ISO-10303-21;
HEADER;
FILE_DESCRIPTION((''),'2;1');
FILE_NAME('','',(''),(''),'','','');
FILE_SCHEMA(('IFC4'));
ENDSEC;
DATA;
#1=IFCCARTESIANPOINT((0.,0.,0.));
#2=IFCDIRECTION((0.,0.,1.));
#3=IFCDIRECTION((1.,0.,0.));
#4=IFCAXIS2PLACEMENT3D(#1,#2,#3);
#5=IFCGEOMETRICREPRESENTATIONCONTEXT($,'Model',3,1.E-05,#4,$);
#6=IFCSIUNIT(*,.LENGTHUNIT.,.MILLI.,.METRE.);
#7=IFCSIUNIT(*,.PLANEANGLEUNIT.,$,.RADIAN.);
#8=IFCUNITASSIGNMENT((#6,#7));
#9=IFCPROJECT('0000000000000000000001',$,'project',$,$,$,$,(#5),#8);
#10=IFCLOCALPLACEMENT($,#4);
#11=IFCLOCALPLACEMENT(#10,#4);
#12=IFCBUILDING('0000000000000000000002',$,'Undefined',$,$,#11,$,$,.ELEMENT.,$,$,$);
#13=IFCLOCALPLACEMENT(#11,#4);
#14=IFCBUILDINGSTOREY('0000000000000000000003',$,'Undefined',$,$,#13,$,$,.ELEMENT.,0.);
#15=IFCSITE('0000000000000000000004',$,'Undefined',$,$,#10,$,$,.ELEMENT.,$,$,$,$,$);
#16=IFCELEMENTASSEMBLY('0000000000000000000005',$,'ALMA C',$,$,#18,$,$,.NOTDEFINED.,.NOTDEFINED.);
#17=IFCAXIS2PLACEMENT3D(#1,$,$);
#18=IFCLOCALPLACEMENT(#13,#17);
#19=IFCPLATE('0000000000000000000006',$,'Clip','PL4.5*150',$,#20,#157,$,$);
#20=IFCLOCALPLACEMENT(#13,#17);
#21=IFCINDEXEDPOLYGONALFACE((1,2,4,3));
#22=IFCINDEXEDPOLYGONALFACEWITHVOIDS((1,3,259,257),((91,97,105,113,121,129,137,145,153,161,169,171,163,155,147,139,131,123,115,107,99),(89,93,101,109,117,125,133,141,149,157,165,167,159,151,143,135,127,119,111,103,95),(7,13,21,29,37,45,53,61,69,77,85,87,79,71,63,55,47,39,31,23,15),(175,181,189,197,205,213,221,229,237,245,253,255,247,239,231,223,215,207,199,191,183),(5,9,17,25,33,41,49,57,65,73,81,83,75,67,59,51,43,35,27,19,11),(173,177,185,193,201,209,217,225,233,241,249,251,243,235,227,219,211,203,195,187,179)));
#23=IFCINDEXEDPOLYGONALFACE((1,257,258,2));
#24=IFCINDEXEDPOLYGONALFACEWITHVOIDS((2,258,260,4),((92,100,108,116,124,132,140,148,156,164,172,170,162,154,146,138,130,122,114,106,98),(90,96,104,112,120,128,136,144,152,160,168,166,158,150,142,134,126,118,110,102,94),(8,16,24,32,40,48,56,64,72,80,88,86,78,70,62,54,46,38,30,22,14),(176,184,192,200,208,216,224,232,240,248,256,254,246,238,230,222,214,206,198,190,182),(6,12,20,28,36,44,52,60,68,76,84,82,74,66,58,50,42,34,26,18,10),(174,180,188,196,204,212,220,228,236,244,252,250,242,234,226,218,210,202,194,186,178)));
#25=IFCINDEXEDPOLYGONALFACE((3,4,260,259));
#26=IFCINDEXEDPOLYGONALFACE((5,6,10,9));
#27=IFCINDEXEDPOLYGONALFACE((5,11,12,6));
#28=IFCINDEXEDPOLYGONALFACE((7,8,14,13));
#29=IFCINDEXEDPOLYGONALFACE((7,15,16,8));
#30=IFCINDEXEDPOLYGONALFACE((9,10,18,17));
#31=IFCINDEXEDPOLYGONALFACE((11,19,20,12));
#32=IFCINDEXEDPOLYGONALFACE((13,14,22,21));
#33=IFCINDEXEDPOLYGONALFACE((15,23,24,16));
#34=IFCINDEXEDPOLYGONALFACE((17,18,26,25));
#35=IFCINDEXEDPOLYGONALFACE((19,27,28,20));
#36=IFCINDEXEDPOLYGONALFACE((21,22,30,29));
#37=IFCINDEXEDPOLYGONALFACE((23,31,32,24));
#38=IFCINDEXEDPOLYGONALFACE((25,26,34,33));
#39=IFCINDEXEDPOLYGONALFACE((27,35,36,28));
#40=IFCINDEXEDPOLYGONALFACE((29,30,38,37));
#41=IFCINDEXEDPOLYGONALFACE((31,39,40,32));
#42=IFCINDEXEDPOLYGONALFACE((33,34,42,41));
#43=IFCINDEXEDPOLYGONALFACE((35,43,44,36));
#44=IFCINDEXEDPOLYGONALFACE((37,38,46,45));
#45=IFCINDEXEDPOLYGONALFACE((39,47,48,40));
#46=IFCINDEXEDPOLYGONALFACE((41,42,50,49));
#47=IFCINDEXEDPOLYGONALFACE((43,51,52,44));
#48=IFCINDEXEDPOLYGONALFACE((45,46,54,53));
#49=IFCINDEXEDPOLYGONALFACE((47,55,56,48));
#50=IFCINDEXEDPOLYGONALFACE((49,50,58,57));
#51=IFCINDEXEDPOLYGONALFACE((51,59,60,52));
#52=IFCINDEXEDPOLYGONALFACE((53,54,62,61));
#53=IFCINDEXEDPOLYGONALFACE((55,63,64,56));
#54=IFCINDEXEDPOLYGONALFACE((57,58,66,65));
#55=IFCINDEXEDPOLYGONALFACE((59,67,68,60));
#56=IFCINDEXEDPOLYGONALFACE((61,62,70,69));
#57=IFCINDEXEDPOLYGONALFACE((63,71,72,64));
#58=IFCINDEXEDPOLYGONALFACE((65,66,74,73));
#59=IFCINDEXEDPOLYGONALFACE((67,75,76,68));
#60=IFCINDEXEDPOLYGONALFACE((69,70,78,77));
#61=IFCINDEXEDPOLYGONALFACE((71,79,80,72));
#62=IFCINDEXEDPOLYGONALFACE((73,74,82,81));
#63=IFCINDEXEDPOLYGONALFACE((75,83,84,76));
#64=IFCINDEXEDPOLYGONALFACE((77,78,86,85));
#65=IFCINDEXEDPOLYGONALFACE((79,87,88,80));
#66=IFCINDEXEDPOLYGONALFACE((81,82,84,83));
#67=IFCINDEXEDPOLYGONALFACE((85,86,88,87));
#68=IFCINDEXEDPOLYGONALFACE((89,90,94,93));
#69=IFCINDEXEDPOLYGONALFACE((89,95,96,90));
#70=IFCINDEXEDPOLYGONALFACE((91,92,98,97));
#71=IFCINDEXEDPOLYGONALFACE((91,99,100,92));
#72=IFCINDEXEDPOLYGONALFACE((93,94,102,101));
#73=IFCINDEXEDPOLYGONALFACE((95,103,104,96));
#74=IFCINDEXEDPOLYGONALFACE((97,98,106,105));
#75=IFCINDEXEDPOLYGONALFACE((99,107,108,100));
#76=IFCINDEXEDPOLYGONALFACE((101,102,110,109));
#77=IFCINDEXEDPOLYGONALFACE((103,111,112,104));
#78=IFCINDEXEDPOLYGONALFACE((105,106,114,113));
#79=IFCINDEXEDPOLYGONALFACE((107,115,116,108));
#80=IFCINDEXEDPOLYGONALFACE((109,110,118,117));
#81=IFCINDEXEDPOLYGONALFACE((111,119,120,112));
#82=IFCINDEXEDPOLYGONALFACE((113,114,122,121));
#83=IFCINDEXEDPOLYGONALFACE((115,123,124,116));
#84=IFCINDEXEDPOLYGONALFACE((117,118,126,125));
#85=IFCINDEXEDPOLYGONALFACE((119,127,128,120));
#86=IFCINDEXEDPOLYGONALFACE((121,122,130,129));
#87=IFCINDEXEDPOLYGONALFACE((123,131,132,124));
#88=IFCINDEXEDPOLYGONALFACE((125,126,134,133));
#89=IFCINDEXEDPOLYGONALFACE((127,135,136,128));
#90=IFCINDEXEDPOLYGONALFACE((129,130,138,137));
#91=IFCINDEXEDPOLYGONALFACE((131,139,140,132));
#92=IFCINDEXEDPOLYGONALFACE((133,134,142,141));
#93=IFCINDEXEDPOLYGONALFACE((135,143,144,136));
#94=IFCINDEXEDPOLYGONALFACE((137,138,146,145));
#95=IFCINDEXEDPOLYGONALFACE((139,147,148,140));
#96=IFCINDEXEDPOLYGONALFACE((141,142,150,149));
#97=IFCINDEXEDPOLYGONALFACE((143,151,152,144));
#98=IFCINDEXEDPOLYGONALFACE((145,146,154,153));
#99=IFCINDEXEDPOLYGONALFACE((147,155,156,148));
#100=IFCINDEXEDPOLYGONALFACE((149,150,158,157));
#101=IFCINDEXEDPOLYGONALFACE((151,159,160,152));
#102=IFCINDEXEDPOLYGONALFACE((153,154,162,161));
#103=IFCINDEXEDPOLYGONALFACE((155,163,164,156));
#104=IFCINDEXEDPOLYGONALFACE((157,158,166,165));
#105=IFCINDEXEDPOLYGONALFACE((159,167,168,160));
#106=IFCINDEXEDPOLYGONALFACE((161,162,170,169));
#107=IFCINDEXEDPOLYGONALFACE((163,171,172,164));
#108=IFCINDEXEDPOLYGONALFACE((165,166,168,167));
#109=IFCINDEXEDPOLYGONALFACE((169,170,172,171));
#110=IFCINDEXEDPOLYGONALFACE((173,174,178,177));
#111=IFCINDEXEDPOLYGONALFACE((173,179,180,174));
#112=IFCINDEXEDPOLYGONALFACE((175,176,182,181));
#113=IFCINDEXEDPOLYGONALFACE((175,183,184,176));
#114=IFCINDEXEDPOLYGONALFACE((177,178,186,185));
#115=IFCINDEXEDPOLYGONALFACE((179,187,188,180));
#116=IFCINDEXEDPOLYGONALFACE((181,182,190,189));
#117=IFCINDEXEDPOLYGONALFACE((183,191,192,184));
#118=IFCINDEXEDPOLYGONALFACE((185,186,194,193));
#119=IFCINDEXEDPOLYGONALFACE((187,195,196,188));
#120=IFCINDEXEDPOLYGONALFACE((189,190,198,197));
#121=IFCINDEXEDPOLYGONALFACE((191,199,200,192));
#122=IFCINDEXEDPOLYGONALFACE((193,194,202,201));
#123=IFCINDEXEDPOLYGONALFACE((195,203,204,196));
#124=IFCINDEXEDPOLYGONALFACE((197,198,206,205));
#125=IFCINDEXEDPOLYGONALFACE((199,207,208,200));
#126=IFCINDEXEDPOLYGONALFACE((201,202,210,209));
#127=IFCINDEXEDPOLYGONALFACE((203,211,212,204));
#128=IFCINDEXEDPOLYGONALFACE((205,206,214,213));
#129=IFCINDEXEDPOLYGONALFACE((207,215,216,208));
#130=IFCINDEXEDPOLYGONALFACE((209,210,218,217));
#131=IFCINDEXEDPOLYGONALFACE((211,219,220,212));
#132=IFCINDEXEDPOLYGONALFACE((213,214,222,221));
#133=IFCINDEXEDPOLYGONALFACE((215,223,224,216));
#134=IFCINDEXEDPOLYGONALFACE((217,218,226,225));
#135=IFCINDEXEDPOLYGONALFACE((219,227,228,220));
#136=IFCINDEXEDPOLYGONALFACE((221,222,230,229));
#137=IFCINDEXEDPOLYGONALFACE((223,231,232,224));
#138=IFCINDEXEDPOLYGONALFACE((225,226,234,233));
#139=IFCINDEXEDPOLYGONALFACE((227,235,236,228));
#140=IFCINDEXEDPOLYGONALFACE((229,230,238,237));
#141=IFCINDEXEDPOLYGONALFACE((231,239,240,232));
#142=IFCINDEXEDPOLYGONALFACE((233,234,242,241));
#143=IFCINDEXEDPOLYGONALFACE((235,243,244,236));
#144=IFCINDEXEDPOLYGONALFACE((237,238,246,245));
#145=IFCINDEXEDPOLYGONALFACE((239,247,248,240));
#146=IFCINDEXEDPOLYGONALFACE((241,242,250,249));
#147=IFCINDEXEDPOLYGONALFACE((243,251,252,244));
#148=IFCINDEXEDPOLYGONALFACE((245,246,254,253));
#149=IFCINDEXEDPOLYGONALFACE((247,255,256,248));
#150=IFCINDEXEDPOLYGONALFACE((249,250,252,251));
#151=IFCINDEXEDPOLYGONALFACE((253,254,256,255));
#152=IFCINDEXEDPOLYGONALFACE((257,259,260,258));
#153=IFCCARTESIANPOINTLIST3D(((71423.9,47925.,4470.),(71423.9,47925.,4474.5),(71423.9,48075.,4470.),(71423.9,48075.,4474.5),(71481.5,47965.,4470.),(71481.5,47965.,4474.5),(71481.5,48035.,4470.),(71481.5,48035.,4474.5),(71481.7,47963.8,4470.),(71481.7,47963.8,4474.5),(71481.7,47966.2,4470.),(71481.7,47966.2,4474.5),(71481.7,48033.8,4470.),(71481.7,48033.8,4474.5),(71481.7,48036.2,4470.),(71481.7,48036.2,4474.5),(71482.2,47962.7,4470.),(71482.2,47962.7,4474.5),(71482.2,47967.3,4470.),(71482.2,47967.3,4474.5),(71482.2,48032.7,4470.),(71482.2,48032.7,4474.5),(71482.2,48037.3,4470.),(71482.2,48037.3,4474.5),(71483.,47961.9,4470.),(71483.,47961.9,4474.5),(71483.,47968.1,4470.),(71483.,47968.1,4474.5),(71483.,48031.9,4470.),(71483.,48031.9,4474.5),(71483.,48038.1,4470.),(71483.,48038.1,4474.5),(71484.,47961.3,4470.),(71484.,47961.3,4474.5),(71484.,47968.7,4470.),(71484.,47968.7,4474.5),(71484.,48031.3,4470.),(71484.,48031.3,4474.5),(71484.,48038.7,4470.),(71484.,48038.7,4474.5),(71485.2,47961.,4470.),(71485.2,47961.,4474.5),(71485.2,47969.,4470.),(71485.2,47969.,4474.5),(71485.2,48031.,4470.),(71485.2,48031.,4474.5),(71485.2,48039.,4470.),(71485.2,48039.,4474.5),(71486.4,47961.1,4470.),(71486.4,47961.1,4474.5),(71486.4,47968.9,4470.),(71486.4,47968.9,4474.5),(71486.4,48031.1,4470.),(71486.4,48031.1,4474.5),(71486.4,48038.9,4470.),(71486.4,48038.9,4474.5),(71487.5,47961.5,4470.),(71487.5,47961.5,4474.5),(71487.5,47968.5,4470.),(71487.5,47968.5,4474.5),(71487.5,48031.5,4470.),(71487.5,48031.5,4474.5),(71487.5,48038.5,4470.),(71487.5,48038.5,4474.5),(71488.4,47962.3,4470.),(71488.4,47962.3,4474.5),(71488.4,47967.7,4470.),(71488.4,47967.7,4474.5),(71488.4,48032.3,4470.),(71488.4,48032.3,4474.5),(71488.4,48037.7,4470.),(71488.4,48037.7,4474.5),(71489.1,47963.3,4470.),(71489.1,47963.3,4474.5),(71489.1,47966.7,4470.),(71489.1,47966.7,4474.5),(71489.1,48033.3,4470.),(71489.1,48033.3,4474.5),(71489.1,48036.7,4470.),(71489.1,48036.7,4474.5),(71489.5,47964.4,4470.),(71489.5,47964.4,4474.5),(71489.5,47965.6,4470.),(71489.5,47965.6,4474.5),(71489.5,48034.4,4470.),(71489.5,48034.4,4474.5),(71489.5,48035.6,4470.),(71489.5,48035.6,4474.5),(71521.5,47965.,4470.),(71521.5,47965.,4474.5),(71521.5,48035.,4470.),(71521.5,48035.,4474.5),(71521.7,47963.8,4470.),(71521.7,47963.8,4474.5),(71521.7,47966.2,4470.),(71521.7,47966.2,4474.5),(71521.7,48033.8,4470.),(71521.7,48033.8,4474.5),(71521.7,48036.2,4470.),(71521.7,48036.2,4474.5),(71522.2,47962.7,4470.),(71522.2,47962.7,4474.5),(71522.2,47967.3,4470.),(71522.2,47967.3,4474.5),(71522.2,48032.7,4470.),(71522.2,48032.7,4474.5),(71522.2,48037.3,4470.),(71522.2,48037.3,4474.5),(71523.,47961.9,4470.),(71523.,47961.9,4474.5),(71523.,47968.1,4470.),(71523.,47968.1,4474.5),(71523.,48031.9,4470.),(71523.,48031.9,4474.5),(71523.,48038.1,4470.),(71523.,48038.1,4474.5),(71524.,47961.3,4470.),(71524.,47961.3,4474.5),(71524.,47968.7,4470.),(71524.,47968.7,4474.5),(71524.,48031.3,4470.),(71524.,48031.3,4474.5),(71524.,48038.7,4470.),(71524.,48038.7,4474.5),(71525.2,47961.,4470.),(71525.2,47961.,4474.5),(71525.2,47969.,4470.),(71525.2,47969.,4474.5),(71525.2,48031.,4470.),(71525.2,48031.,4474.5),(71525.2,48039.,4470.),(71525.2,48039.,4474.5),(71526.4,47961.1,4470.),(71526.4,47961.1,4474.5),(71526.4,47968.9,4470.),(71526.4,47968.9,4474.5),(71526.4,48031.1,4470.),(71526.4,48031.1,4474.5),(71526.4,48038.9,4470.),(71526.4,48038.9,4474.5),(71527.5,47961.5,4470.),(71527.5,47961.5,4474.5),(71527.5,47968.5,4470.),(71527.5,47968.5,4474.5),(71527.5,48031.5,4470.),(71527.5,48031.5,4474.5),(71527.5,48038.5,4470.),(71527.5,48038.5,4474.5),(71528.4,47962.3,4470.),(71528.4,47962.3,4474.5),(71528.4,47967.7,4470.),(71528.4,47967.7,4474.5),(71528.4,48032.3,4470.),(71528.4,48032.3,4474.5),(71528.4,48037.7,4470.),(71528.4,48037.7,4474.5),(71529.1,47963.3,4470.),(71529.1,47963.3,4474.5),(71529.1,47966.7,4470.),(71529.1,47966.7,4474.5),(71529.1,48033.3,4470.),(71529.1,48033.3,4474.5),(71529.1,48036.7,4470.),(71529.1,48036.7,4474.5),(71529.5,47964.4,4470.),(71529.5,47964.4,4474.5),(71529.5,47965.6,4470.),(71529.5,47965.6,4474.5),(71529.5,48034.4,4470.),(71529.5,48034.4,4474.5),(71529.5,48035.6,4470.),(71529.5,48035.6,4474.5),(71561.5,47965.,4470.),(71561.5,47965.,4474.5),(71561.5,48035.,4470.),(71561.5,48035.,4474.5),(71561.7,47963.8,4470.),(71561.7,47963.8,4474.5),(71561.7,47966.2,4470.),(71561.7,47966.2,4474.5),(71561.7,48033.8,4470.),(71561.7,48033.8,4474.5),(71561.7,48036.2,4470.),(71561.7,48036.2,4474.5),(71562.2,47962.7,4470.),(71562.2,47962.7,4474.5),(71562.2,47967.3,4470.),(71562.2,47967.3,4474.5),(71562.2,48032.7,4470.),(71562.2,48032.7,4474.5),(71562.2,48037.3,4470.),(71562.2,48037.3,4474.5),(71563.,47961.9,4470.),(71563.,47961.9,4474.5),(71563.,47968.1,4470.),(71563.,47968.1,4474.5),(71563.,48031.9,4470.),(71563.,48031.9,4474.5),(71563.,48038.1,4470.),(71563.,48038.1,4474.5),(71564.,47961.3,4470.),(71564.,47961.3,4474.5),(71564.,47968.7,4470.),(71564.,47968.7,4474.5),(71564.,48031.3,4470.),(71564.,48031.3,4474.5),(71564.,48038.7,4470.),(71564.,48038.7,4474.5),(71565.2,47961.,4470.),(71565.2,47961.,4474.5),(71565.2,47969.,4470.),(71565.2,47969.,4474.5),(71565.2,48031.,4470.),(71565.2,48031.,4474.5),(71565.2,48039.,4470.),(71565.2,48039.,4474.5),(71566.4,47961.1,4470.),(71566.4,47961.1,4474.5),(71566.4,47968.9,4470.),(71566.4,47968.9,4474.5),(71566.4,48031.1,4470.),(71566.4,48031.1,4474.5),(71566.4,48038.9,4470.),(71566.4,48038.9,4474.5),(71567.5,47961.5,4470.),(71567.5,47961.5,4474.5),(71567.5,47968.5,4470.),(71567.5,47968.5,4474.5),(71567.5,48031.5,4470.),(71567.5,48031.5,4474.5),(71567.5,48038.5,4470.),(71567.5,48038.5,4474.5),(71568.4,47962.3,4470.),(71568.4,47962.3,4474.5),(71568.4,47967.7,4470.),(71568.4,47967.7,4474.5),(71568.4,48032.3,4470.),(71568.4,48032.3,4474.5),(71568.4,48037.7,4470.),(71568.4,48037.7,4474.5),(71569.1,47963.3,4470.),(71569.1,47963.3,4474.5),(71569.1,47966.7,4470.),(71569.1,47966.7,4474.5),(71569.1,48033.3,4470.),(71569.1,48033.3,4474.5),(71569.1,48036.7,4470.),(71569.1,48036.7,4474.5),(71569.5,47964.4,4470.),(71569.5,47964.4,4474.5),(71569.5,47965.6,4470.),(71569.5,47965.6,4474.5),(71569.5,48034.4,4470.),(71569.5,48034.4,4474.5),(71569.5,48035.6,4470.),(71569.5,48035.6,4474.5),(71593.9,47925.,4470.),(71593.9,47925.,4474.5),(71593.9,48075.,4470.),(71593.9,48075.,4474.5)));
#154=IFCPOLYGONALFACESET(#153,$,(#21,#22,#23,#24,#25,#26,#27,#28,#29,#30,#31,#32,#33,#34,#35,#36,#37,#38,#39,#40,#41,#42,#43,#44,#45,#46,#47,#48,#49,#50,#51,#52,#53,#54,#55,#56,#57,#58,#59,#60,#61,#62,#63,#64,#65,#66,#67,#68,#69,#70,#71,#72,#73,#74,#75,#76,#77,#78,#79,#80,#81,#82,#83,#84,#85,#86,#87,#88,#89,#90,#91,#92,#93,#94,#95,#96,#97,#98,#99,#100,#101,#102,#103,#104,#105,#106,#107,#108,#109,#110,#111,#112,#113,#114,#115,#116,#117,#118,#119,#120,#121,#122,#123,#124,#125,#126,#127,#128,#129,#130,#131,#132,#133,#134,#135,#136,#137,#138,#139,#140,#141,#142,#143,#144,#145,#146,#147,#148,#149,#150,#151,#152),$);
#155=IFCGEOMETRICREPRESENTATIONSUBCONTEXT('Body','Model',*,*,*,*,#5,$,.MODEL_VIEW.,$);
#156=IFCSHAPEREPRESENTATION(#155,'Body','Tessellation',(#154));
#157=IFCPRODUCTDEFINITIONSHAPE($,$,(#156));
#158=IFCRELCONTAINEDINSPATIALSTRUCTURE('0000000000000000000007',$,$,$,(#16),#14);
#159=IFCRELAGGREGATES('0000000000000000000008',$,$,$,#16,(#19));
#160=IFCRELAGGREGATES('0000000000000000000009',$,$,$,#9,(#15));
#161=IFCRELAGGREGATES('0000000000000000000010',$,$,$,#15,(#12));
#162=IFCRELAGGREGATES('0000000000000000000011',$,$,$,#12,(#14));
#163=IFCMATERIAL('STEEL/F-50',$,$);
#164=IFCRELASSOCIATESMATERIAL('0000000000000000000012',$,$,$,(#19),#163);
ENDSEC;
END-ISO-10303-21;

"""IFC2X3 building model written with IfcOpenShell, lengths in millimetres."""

from ifc_helpers import new_model, si_unit, frame, origin_with_axes, origin_2d_with_axis, place, context, subcontext, project, spatial, polyline, circle, outline, extrude, source, transform, mapped, material, element, aggregate, save


model = new_model("IFC2X3")

# Units and contexts
model_context = context("Model", 3, precision=1e-05, world=origin_with_axes())
body_context = subcontext(model_context, "Body", "Model", "MODEL_VIEW")
ifc_project = project(units=[si_unit("LENGTHUNIT", "METRE", prefix="MILLI"), si_unit("PLANEANGLEUNIT", "RADIAN")], contexts=[model_context])

# Site, building, storey
site_placement = place(None, origin_with_axes())
site = spatial("IfcSite", under=ifc_project, at=site_placement, Name="Undefined", CompositionType="ELEMENT")
building_placement = place(site_placement, origin_with_axes())
building = spatial("IfcBuilding", under=site, at=building_placement, Name="Undefined", CompositionType="ELEMENT")
storey_placement = place(building_placement, origin_with_axes())
storey = spatial("IfcBuildingStorey", under=building, at=storey_placement, Name="Undefined", CompositionType="ELEMENT", Elevation=0.0)

# Element assembly
assembly_1_placement = place(storey_placement, origin_with_axes())
assembly_1 = element("IfcElementAssembly", 1, at=assembly_1_placement, inside=storey, Name="ALMA C", AssemblyPlace="NOTDEFINED", PredefinedType="NOTDEFINED")
ifc_material_1 = material(Name="STEEL/F-50")

# Plate, openings
plate_1_placement = place(assembly_1_placement, frame((71423.9, 48075.0, 4472.2), z_axis=(0.0, 0.0, -1.0), x_axis=(1.0, 0.0, 0.0)))
plate_1 = element("IfcPlate", 2, at=plate_1_placement, material=ifc_material_1, Name="Clip", Description="PL4.5*150", context=body_context, shape_type="SweptSolid", body=[
    extrude(outline(polyline([(0.0, 0.0), (170.0, 0.0), (170.0, 150.0), (0.0, 150.0), (0.0, 0.0)])), frame((0.0, 0.0, -2.2), z_axis=(0.0, 0.0, 1.0), x_axis=(1.0, 0.0, 0.0)), (0.0, 0.0, 1.0), 4.5),
])
shared_shape_1 = source(origin_with_axes(), body_context, "Body", "SweptSolid", [
    extrude(circle(Radius=4.0, at=origin_2d_with_axis()), frame((0.0, -4.6, 0.0), z_axis=(0.0, 1.0, 0.0), x_axis=(1.0, 0.0, 0.0)), (0.0, 0.0, 1.0), 4.7),
])
opening_1_placement = place(assembly_1_placement, frame((71565.5, 47965.0, 4470.0), z_axis=(0.0, -1.0, 0.0), x_axis=(-1.0, 0.0, 0.0)))
element("IfcOpeningElement", 3, at=opening_1_placement, cuts=plate_1, ObjectType="Opening", context=body_context, shape_type="MappedRepresentation", body=[
    mapped(shared_shape_1, transform((0.0, 0.0, 0.0))),
    mapped(shared_shape_1, transform((40.0, 0.0, 0.0))),
    mapped(shared_shape_1, transform((80.0, 0.0, 0.0))),
])
opening_2_placement = place(assembly_1_placement, frame((71565.5, 48035.0, 4470.0), z_axis=(0.0, -1.0, 0.0), x_axis=(-1.0, 0.0, 0.0)))
element("IfcOpeningElement", 4, at=opening_2_placement, cuts=plate_1, ObjectType="Opening", context=body_context, shape_type="MappedRepresentation", body=[
    mapped(shared_shape_1, transform((0.0, 0.0, 0.0))),
    mapped(shared_shape_1, transform((40.0, 0.0, 0.0))),
    mapped(shared_shape_1, transform((80.0, 0.0, 0.0))),
])

aggregate(assembly_1, [plate_1])

save(model, "model.ifc")
